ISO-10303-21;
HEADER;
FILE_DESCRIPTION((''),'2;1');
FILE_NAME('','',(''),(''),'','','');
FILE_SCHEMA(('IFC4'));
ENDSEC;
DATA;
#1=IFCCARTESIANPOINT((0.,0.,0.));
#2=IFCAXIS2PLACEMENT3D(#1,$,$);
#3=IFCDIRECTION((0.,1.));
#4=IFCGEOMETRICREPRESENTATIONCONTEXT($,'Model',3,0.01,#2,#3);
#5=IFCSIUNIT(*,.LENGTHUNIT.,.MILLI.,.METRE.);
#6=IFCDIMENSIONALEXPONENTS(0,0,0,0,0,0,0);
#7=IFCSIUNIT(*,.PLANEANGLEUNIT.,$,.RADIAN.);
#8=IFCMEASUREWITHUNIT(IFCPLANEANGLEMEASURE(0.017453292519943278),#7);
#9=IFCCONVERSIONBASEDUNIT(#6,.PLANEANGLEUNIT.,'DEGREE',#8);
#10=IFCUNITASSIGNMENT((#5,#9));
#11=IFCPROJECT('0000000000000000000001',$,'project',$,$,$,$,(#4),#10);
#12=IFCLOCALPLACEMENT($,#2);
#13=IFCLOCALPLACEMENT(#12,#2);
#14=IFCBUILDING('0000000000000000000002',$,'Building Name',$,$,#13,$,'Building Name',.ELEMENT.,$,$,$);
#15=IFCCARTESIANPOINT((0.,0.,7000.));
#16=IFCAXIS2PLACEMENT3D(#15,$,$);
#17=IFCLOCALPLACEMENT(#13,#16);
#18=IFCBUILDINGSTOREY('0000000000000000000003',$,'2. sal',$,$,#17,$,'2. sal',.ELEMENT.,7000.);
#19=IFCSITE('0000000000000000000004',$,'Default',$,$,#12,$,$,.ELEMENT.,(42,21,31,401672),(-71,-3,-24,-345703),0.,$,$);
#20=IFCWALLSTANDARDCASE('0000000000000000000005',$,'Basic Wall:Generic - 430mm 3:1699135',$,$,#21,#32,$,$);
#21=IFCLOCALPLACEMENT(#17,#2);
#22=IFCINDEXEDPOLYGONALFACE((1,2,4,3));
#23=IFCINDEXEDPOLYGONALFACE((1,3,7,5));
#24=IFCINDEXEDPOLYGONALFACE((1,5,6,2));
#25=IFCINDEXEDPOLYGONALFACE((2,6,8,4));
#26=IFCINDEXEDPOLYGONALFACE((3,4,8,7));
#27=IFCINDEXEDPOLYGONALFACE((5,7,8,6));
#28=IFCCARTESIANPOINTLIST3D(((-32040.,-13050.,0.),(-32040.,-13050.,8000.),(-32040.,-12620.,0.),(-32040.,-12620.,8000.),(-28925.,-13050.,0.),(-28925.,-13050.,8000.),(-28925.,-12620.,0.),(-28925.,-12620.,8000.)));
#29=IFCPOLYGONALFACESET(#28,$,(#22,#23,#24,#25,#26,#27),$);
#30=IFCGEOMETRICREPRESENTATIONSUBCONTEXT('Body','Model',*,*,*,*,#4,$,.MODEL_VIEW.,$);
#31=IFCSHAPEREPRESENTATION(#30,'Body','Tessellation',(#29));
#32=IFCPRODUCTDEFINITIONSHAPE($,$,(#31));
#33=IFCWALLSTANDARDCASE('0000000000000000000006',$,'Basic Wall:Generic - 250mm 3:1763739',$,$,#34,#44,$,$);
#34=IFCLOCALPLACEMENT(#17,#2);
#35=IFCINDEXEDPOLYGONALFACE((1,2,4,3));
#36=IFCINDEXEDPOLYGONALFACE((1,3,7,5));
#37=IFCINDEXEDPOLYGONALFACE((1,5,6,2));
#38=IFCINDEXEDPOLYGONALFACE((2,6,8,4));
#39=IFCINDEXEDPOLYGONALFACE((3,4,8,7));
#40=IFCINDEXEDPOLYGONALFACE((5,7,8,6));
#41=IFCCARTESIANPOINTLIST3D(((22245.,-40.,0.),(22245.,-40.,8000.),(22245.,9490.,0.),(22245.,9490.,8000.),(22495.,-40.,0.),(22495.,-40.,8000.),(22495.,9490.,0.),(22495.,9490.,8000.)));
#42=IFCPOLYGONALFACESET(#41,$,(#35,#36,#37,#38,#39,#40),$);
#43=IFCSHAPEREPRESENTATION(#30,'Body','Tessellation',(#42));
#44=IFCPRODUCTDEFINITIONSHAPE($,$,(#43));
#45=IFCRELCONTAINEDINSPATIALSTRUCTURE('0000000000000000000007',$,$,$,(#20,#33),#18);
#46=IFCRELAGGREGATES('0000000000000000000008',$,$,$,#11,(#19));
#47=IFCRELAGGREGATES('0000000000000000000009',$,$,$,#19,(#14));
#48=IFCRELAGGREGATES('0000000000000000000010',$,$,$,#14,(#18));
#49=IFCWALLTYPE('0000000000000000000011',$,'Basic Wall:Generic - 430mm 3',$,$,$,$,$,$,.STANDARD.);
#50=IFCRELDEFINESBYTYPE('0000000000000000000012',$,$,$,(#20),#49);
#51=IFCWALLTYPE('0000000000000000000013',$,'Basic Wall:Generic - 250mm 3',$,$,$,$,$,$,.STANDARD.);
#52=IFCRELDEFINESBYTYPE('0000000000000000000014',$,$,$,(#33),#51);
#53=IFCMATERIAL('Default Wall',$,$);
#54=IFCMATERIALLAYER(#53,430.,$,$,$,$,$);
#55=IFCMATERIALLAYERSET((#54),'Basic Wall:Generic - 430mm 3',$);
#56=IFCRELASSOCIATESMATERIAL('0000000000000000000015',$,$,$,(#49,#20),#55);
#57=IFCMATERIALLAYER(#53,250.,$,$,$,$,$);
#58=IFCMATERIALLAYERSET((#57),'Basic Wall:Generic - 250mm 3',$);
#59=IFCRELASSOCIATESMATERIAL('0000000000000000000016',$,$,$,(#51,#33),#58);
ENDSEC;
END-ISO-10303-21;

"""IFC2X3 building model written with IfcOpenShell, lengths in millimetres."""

from ifc_helpers import new_model, entity, si_unit, converted_unit, direction, frame, frame_2d, origin, place, context, subcontext, project, spatial, rectangle, extrude, material, layer, layer_set, layer_usage, type_object, element, save


model = new_model("IFC2X3")

# Units and contexts
model_context = context("Model", 3, precision=0.01, world=origin(), true_north=direction((0.0, 1.0)))
body_context = subcontext(model_context, "Body", "Model", "MODEL_VIEW")
ifc_project = project(units=[si_unit("LENGTHUNIT", "METRE", prefix="MILLI"), converted_unit("PLANEANGLEUNIT", "DEGREE", entity("IfcPlaneAngleMeasure", 0.017453292519943278), si_unit("PLANEANGLEUNIT", "RADIAN"), dimensions=[0, 0, 0, 0, 0, 0, 0])], contexts=[model_context])

# Site, building, storey
site_placement = place(None, origin())
site = spatial("IfcSite", under=ifc_project, at=site_placement, Name="Default", CompositionType="ELEMENT", RefLatitude=(42, 21, 31, 401672), RefLongitude=(-71, -3, -24, -345703), RefElevation=0.0)
building_placement = place(site_placement, origin())
building = spatial("IfcBuilding", under=site, at=building_placement, Name="Building Name", LongName="Building Name", CompositionType="ELEMENT")
storey_placement = place(building_placement, frame((0.0, 0.0, 7000.0)))
storey = spatial("IfcBuildingStorey", under=building, at=storey_placement, Name="2. sal", LongName="2. sal", CompositionType="ELEMENT", Elevation=7000.0)

# Walls
ifc_material_1 = material(Name="Default Wall")
ifc_layer_1 = layer(ifc_material_1, 430.0)
ifc_layer_set_1 = layer_set([ifc_layer_1], Name="Basic Wall:Generic - 430mm 3")
ifc_layer_usage_1 = layer_usage(ifc_layer_set_1, "AXIS2", "NEGATIVE", 215.0)
wall_type_1 = type_object("IfcWallType", Name="Basic Wall:Generic - 430mm 3", PredefinedType="STANDARD", material=ifc_layer_set_1)
wall_1_placement = place(storey_placement, frame((-32040.0, -12835.0, 0.0)))
element("IfcWallStandardCase", 1, at=wall_1_placement, inside=storey, type_object=wall_type_1, material=ifc_layer_usage_1, Name="Basic Wall:Generic - 430mm 3:1699135", context=body_context, shape_type="SweptSolid", body=[
    extrude(rectangle(XDim=3115.0, YDim=430.0, at=frame_2d((1557.5, 0.0), x_axis=(-1.0, 0.0))), origin(), (0.0, 0.0, 1.0), 8000.0),
])
ifc_layer_2 = layer(ifc_material_1, 250.0)
ifc_layer_set_2 = layer_set([ifc_layer_2], Name="Basic Wall:Generic - 250mm 3")
ifc_layer_usage_2 = layer_usage(ifc_layer_set_2, "AXIS2", "NEGATIVE", 125.0)
wall_type_2 = type_object("IfcWallType", Name="Basic Wall:Generic - 250mm 3", PredefinedType="STANDARD", material=ifc_layer_set_2)
wall_2_placement = place(storey_placement, frame((22370.0, -40.0, 0.0), z_axis=(0.0, 0.0, 1.0), x_axis=(0.0, 1.0, 0.0)))
element("IfcWallStandardCase", 2, at=wall_2_placement, inside=storey, type_object=wall_type_2, material=ifc_layer_usage_2, Name="Basic Wall:Generic - 250mm 3:1763739", context=body_context, shape_type="SweptSolid", body=[
    extrude(rectangle(XDim=9530.0, YDim=250.0, at=frame_2d((4765.0, 0.0), x_axis=(-1.0, 0.0))), origin(), (0.0, 0.0, 1.0), 8000.0),
])

save(model, "model.ifc")
